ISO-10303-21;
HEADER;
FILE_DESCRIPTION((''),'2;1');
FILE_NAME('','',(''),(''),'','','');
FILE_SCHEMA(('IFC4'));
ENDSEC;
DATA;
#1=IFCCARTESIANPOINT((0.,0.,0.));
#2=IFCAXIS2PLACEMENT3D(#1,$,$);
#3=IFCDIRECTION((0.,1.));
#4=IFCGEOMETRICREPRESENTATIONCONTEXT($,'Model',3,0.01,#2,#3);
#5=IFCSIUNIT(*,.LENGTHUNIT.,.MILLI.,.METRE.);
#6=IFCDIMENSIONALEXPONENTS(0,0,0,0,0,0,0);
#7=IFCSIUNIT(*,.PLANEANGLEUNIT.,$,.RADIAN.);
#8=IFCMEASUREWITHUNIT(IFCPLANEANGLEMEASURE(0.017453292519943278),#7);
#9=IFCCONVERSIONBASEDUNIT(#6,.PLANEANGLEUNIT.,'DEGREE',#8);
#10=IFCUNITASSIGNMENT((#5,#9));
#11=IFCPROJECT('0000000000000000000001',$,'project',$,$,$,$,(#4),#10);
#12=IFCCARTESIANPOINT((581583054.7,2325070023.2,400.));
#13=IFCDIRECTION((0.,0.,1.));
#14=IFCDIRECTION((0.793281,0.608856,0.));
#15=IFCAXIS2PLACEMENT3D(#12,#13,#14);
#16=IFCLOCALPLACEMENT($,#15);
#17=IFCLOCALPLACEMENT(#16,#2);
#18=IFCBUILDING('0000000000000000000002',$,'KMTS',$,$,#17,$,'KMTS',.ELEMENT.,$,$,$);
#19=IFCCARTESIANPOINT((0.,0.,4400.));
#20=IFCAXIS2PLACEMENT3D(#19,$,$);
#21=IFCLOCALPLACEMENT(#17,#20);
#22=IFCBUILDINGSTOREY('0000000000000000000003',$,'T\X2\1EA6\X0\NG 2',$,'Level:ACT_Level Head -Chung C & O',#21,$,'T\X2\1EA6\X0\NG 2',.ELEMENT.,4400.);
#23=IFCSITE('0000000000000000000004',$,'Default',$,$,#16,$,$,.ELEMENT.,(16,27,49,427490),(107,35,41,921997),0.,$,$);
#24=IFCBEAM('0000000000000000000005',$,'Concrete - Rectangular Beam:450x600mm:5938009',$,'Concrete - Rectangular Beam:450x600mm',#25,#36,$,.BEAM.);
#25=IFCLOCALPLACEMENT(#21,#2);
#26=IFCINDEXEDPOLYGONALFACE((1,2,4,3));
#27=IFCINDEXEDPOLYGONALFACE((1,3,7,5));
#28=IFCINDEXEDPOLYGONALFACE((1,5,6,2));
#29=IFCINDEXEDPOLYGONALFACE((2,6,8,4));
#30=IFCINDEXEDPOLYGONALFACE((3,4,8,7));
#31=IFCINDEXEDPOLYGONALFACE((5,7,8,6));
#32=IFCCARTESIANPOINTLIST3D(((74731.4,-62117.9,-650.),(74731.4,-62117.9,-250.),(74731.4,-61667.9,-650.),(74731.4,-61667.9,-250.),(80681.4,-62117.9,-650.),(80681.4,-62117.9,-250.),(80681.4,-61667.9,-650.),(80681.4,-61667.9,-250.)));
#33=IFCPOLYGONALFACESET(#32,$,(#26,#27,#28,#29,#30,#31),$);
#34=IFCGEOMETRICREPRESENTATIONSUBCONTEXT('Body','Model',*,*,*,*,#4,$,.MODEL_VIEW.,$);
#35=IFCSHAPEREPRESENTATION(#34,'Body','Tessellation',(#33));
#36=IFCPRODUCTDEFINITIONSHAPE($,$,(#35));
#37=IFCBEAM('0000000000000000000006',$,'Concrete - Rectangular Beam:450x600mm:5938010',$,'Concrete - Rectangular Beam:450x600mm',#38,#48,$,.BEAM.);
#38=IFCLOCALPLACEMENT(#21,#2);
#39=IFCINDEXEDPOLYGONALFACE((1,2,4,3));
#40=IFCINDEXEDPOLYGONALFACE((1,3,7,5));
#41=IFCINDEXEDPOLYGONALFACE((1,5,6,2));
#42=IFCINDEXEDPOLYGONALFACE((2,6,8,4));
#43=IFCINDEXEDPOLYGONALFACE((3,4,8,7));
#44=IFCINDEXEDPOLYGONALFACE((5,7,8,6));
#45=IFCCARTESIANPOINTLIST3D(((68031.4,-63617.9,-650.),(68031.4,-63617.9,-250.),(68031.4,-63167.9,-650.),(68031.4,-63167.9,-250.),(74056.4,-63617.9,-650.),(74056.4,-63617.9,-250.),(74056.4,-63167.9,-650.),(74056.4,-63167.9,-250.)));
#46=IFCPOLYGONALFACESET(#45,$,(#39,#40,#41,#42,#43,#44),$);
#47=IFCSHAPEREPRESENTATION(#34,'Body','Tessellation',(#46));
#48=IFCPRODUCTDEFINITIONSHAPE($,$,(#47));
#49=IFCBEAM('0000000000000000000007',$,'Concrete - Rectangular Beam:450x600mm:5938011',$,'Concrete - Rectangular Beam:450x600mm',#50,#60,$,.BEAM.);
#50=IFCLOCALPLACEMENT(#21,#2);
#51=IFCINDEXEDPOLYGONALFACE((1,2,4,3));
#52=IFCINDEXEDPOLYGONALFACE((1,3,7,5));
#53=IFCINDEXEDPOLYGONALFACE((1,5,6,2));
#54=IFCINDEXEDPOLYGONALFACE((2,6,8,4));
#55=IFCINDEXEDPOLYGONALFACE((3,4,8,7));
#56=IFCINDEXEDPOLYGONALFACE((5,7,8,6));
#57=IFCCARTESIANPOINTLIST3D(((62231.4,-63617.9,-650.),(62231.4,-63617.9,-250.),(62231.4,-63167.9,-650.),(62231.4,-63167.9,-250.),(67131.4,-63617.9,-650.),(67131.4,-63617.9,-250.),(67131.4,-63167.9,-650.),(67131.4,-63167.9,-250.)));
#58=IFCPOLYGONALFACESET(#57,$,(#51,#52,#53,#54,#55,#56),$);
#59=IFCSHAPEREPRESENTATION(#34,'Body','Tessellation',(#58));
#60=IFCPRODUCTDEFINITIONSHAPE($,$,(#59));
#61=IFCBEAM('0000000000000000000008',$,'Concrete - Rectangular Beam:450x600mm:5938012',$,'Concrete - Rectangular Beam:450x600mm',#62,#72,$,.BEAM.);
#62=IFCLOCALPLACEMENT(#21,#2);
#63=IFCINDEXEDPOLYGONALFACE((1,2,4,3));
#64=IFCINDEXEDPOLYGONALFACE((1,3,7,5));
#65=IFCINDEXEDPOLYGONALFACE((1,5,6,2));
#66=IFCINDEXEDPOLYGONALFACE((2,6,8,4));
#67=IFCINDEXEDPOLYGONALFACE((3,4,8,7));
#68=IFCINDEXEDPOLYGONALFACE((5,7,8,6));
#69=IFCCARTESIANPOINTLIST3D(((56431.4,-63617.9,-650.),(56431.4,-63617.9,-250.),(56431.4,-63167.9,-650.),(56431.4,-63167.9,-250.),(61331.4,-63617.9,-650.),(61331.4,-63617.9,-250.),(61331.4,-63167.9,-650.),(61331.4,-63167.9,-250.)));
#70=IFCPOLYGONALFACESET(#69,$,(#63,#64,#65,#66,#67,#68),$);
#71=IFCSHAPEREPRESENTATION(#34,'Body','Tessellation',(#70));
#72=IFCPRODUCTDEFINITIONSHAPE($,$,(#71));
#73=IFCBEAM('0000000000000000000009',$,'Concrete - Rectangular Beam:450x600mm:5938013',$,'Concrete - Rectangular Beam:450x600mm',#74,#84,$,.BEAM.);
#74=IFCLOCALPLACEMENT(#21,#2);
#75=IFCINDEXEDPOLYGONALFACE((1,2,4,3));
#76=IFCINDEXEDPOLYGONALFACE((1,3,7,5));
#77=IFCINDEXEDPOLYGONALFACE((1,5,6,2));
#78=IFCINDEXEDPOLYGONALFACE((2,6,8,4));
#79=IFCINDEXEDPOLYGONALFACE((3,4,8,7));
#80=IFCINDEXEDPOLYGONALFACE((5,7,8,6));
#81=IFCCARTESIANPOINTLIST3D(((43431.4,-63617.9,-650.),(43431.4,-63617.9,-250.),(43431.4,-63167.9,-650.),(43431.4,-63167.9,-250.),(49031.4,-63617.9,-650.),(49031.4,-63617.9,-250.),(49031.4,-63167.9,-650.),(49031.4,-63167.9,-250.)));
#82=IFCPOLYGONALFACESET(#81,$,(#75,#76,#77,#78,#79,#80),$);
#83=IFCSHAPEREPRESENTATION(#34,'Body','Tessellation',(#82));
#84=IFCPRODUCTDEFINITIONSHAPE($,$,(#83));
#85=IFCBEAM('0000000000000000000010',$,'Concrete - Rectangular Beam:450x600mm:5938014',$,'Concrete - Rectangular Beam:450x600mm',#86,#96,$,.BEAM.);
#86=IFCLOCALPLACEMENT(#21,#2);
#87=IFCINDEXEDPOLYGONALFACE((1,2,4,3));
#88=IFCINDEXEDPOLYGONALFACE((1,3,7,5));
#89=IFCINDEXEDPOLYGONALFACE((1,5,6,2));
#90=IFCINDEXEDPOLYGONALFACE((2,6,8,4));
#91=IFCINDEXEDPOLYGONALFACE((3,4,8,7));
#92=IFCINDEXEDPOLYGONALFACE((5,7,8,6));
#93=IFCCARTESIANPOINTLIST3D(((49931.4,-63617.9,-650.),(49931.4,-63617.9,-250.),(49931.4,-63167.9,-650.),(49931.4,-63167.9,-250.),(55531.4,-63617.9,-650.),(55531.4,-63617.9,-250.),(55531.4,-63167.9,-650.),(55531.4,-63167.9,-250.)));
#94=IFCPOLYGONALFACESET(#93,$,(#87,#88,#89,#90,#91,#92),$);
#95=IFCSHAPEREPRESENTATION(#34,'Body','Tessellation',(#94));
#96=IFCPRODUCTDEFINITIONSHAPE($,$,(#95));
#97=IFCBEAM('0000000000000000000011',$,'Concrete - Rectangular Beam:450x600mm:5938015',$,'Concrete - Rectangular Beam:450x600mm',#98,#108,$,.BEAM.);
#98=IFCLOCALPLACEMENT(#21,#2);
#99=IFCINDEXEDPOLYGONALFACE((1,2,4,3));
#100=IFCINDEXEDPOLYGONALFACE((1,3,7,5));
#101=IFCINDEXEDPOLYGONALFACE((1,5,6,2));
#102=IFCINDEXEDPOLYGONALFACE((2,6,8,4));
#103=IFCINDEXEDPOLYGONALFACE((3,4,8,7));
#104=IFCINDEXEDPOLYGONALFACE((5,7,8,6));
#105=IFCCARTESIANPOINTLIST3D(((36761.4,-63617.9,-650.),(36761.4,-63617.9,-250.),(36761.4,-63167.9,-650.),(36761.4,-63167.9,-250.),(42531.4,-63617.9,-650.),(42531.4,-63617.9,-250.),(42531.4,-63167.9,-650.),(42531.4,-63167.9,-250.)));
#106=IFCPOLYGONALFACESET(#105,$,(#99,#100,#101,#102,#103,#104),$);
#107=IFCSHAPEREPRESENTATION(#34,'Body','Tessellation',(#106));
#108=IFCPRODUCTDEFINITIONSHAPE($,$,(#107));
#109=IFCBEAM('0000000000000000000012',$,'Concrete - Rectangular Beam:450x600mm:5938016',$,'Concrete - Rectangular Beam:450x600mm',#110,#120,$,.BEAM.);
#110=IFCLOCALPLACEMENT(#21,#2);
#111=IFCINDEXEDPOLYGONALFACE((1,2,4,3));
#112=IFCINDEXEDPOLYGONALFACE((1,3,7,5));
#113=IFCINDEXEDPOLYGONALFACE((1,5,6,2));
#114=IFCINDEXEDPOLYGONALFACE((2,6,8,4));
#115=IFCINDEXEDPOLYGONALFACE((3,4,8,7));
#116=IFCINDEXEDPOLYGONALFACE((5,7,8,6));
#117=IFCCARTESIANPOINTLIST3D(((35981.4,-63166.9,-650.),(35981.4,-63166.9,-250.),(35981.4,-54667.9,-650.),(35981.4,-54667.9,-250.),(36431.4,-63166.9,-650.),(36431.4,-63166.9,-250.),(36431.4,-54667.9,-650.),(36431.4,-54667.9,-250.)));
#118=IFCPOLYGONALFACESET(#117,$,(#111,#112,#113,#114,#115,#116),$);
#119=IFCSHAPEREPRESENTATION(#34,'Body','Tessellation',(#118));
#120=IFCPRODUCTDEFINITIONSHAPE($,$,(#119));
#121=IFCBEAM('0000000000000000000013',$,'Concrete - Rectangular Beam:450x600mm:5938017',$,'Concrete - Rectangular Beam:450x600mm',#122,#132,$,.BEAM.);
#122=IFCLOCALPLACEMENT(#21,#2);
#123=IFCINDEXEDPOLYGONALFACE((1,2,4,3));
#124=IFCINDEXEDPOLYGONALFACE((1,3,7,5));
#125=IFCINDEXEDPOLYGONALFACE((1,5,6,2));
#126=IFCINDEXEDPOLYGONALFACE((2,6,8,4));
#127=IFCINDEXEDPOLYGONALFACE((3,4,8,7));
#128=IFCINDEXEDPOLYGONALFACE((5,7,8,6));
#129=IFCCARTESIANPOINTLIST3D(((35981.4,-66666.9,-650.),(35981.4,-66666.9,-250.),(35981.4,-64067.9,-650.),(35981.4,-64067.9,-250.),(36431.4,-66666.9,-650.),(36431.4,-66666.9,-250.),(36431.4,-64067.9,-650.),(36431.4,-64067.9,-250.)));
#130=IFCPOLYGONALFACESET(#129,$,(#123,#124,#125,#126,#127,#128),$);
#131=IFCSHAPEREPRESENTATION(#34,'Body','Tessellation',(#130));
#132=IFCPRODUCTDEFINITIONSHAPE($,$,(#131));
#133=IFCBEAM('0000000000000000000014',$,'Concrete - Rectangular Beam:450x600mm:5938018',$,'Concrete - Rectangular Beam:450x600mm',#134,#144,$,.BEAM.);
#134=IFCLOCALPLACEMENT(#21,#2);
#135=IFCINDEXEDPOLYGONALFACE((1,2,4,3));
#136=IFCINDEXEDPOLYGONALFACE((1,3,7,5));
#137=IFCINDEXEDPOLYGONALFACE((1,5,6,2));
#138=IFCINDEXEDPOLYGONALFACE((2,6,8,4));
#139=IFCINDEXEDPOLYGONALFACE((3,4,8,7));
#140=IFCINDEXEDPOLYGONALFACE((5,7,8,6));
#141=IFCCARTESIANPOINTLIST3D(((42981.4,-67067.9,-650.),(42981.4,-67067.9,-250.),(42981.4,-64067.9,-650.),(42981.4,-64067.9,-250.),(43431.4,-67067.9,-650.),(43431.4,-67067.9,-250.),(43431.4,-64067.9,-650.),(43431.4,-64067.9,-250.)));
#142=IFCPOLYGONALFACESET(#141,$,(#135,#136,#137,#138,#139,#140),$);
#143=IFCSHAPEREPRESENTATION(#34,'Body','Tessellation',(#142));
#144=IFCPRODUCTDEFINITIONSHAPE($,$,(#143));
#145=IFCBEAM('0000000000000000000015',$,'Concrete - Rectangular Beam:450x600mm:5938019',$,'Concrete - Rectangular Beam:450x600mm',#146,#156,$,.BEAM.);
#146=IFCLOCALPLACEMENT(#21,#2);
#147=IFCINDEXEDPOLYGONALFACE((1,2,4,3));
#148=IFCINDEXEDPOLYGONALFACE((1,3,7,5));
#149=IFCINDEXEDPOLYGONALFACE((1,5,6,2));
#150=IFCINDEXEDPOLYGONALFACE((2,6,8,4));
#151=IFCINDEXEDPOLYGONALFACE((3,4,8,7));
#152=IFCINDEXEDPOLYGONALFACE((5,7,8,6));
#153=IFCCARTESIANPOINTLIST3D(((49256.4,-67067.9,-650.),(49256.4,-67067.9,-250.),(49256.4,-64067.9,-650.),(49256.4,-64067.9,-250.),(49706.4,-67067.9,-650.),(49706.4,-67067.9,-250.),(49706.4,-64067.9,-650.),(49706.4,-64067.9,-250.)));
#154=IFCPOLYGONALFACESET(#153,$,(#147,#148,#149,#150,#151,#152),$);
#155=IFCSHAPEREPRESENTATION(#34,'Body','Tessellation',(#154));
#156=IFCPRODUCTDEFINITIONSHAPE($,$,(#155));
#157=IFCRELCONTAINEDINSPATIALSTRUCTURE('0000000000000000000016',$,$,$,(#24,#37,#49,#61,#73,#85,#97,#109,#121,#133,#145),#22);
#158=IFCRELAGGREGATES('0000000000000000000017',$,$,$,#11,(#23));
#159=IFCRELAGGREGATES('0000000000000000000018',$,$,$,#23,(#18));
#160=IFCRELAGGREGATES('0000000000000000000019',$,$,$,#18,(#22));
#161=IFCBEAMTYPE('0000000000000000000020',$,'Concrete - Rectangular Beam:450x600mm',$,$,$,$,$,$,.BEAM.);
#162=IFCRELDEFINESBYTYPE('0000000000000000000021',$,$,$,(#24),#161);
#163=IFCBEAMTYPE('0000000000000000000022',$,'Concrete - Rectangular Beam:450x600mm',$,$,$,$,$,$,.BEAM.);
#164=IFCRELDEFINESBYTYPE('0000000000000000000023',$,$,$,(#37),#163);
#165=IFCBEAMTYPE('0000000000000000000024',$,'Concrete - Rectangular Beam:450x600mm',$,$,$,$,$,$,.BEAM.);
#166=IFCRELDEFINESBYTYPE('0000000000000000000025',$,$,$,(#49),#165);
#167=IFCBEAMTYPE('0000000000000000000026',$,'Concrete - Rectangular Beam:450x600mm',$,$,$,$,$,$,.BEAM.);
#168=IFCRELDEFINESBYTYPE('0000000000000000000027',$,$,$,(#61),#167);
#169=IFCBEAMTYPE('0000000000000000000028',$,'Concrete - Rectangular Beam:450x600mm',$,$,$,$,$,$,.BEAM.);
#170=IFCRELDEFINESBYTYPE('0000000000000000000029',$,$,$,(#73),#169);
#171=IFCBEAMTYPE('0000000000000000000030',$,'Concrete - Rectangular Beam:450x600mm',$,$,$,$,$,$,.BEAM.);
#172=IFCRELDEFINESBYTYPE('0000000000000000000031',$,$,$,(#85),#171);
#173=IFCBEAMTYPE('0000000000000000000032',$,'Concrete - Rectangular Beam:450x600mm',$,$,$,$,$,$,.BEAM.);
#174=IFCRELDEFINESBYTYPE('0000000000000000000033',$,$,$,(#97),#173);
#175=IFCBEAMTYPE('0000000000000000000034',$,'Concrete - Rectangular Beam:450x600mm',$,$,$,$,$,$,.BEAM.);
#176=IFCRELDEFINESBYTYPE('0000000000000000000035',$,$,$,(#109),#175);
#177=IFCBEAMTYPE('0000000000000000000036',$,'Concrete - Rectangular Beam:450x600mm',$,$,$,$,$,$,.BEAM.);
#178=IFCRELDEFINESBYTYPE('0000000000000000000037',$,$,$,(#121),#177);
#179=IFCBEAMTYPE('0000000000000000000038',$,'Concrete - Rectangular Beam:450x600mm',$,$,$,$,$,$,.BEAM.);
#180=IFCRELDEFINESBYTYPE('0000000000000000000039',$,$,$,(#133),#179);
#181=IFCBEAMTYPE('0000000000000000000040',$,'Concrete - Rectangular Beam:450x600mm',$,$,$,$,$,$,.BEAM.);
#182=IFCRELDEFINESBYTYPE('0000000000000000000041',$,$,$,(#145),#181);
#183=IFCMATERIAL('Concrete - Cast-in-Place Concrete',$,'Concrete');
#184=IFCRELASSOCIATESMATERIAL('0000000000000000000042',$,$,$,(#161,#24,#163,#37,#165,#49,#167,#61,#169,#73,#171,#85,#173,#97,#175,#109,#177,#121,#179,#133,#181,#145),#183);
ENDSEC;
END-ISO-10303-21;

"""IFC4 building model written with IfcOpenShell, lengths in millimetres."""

from ifc_helpers import new_model, entity, si_unit, converted_unit, direction, frame, origin, place, context, subcontext, project, spatial, indexed_curve, outline, extrude, source, transform, mapped, material, type_object, type_shapes, element, save


model = new_model("IFC4")

# Units and contexts
model_context = context("Model", 3, precision=0.01, world=origin(), true_north=direction((0.0, 1.0)))
body_context = subcontext(model_context, "Body", "Model", "MODEL_VIEW")
ifc_project = project(units=[si_unit("LENGTHUNIT", "METRE", prefix="MILLI"), converted_unit("PLANEANGLEUNIT", "DEGREE", entity("IfcPlaneAngleMeasure", 0.017453292519943278), si_unit("PLANEANGLEUNIT", "RADIAN"), dimensions=[0, 0, 0, 0, 0, 0, 0])], contexts=[model_context])

# Site, building, storey
site_placement = place(None, frame((581583054.7, 2325070023.2, 400.0), z_axis=(0.0, 0.0, 1.0), x_axis=(0.793281, 0.608856, 0.0)))
site = spatial("IfcSite", under=ifc_project, at=site_placement, Name="Default", CompositionType="ELEMENT", RefLatitude=(16, 27, 49, 427490), RefLongitude=(107, 35, 41, 921997), RefElevation=0.0)
building_placement = place(site_placement, origin())
building = spatial("IfcBuilding", under=site, at=building_placement, Name="KMTS", LongName="KMTS", CompositionType="ELEMENT")
storey_placement = place(building_placement, frame((0.0, 0.0, 4400.0)))
storey = spatial("IfcBuildingStorey", under=building, at=storey_placement, Name="TẦNG 2", ObjectType="Level:ACT_Level Head -Chung C & O", LongName="TẦNG 2", CompositionType="ELEMENT", Elevation=4400.0)

# Beams
ifc_material_1 = material(Name="Concrete - Cast-in-Place Concrete", Category="Concrete")
beam_type_1 = type_object("IfcBeamType", Name="Concrete - Rectangular Beam:450x600mm", PredefinedType="BEAM", material=ifc_material_1)
shared_shape_1 = source(origin(), body_context, "Body", "SweptSolid", [
    extrude(outline(indexed_curve([(-200.0, -225.0), (200.0, -225.0), (200.0, 225.0), (-200.0, 225.0), (-200.0, -225.0)], self_intersect=False)), frame((74731.4, -61892.9, 3950.0), z_axis=(1.0, 0.0, 0.0), x_axis=(0.0, 0.0, -1.0)), (0.0, 0.0, 1.0), 5950.0),
])
type_shapes(beam_type_1, [shared_shape_1])
beam_1_placement = place(storey_placement, frame((0.0, 0.0, -4400.0)))
element("IfcBeam", 1, at=beam_1_placement, inside=storey, type_object=beam_type_1, material=ifc_material_1, Name="Concrete - Rectangular Beam:450x600mm:5938009", ObjectType="Concrete - Rectangular Beam:450x600mm", PredefinedType="BEAM", context=body_context, shape_type="MappedRepresentation", body=[
    mapped(shared_shape_1, transform((0.0, 0.0, 0.0), scale=1.0)),
])
beam_type_2 = type_object("IfcBeamType", Name="Concrete - Rectangular Beam:450x600mm", PredefinedType="BEAM", material=ifc_material_1)
shared_shape_2 = source(origin(), body_context, "Body", "SweptSolid", [
    extrude(outline(indexed_curve([(-200.0, -225.0), (200.0, -225.0), (200.0, 225.0), (-200.0, 225.0), (-200.0, -225.0)], self_intersect=False)), frame((68031.4, -63392.9, 3950.0), z_axis=(1.0, 0.0, 0.0), x_axis=(0.0, 0.0, -1.0)), (0.0, 0.0, 1.0), 6025.0),
])
type_shapes(beam_type_2, [shared_shape_2])
beam_2_placement = place(storey_placement, frame((0.0, 0.0, -4400.0)))
element("IfcBeam", 2, at=beam_2_placement, inside=storey, type_object=beam_type_2, material=ifc_material_1, Name="Concrete - Rectangular Beam:450x600mm:5938010", ObjectType="Concrete - Rectangular Beam:450x600mm", PredefinedType="BEAM", context=body_context, shape_type="MappedRepresentation", body=[
    mapped(shared_shape_2, transform((0.0, 0.0, 0.0), scale=1.0)),
])
beam_type_3 = type_object("IfcBeamType", Name="Concrete - Rectangular Beam:450x600mm", PredefinedType="BEAM", material=ifc_material_1)
shared_shape_3 = source(origin(), body_context, "Body", "SweptSolid", [
    extrude(outline(indexed_curve([(-200.0, -225.0), (200.0, -225.0), (200.0, 225.0), (-200.0, 225.0), (-200.0, -225.0)], self_intersect=False)), frame((62231.4, -63392.9, 3950.0), z_axis=(1.0, 0.0, 0.0), x_axis=(0.0, 0.0, -1.0)), (0.0, 0.0, 1.0), 4900.0),
])
type_shapes(beam_type_3, [shared_shape_3])
beam_3_placement = place(storey_placement, frame((0.0, 0.0, -4400.0)))
element("IfcBeam", 3, at=beam_3_placement, inside=storey, type_object=beam_type_3, material=ifc_material_1, Name="Concrete - Rectangular Beam:450x600mm:5938011", ObjectType="Concrete - Rectangular Beam:450x600mm", PredefinedType="BEAM", context=body_context, shape_type="MappedRepresentation", body=[
    mapped(shared_shape_3, transform((0.0, 0.0, 0.0), scale=1.0)),
])
beam_type_4 = type_object("IfcBeamType", Name="Concrete - Rectangular Beam:450x600mm", PredefinedType="BEAM", material=ifc_material_1)
shared_shape_4 = source(origin(), body_context, "Body", "SweptSolid", [
    extrude(outline(indexed_curve([(-200.0, -225.0), (200.0, -225.0), (200.0, 225.0), (-200.0, 225.0), (-200.0, -225.0)], self_intersect=False)), frame((56431.4, -63392.9, 3950.0), z_axis=(1.0, 0.0, 0.0), x_axis=(0.0, 0.0, -1.0)), (0.0, 0.0, 1.0), 4900.0),
])
type_shapes(beam_type_4, [shared_shape_4])
beam_4_placement = place(storey_placement, frame((0.0, 0.0, -4400.0)))
element("IfcBeam", 4, at=beam_4_placement, inside=storey, type_object=beam_type_4, material=ifc_material_1, Name="Concrete - Rectangular Beam:450x600mm:5938012", ObjectType="Concrete - Rectangular Beam:450x600mm", PredefinedType="BEAM", context=body_context, shape_type="MappedRepresentation", body=[
    mapped(shared_shape_4, transform((0.0, 0.0, 0.0), scale=1.0)),
])
beam_type_5 = type_object("IfcBeamType", Name="Concrete - Rectangular Beam:450x600mm", PredefinedType="BEAM", material=ifc_material_1)
shared_shape_5 = source(origin(), body_context, "Body", "SweptSolid", [
    extrude(outline(indexed_curve([(-200.0, -225.0), (200.0, -225.0), (200.0, 225.0), (-200.0, 225.0), (-200.0, -225.0)], self_intersect=False)), frame((43431.4, -63392.9, 3950.0), z_axis=(1.0, 0.0, 0.0), x_axis=(0.0, 0.0, -1.0)), (0.0, 0.0, 1.0), 5600.0),
])
type_shapes(beam_type_5, [shared_shape_5])
beam_5_placement = place(storey_placement, frame((0.0, 0.0, -4400.0)))
element("IfcBeam", 5, at=beam_5_placement, inside=storey, type_object=beam_type_5, material=ifc_material_1, Name="Concrete - Rectangular Beam:450x600mm:5938013", ObjectType="Concrete - Rectangular Beam:450x600mm", PredefinedType="BEAM", context=body_context, shape_type="MappedRepresentation", body=[
    mapped(shared_shape_5, transform((0.0, 0.0, 0.0), scale=1.0)),
])
beam_type_6 = type_object("IfcBeamType", Name="Concrete - Rectangular Beam:450x600mm", PredefinedType="BEAM", material=ifc_material_1)
shared_shape_6 = source(origin(), body_context, "Body", "SweptSolid", [
    extrude(outline(indexed_curve([(-200.0, -225.0), (200.0, -225.0), (200.0, 225.0), (-200.0, 225.0), (-200.0, -225.0)], self_intersect=False)), frame((49931.4, -63392.9, 3950.0), z_axis=(1.0, 0.0, 0.0), x_axis=(0.0, 0.0, -1.0)), (0.0, 0.0, 1.0), 5600.0),
])
type_shapes(beam_type_6, [shared_shape_6])
beam_6_placement = place(storey_placement, frame((0.0, 0.0, -4400.0)))
element("IfcBeam", 6, at=beam_6_placement, inside=storey, type_object=beam_type_6, material=ifc_material_1, Name="Concrete - Rectangular Beam:450x600mm:5938014", ObjectType="Concrete - Rectangular Beam:450x600mm", PredefinedType="BEAM", context=body_context, shape_type="MappedRepresentation", body=[
    mapped(shared_shape_6, transform((0.0, 0.0, 0.0), scale=1.0)),
])
beam_type_7 = type_object("IfcBeamType", Name="Concrete - Rectangular Beam:450x600mm", PredefinedType="BEAM", material=ifc_material_1)
shared_shape_7 = source(origin(), body_context, "Body", "SweptSolid", [
    extrude(outline(indexed_curve([(-200.0, -225.0), (200.0, -225.0), (200.0, 225.0), (-200.0, 225.0), (-200.0, -225.0)], self_intersect=False)), frame((36761.4, -63392.9, 3950.0), z_axis=(1.0, 0.0, 0.0), x_axis=(0.0, 0.0, -1.0)), (0.0, 0.0, 1.0), 5770.0),
])
type_shapes(beam_type_7, [shared_shape_7])
beam_7_placement = place(storey_placement, frame((0.0, 0.0, -4400.0)))
element("IfcBeam", 7, at=beam_7_placement, inside=storey, type_object=beam_type_7, material=ifc_material_1, Name="Concrete - Rectangular Beam:450x600mm:5938015", ObjectType="Concrete - Rectangular Beam:450x600mm", PredefinedType="BEAM", context=body_context, shape_type="MappedRepresentation", body=[
    mapped(shared_shape_7, transform((0.0, 0.0, 0.0), scale=1.0)),
])
beam_type_8 = type_object("IfcBeamType", Name="Concrete - Rectangular Beam:450x600mm", PredefinedType="BEAM", material=ifc_material_1)
shared_shape_8 = source(origin(), body_context, "Body", "SweptSolid", [
    extrude(outline(indexed_curve([(-225.0, -200.0), (225.0, -200.0), (225.0, 200.0), (-225.0, 200.0), (-225.0, -200.0)], self_intersect=False)), frame((36206.4, -54667.9, 3950.0), z_axis=(0.0, -1.0, 0.0), x_axis=(-1.0, 0.0, 0.0)), (0.0, 0.0, 1.0), 8499.0),
])
type_shapes(beam_type_8, [shared_shape_8])
beam_8_placement = place(storey_placement, frame((0.0, 0.0, -4400.0)))
element("IfcBeam", 8, at=beam_8_placement, inside=storey, type_object=beam_type_8, material=ifc_material_1, Name="Concrete - Rectangular Beam:450x600mm:5938016", ObjectType="Concrete - Rectangular Beam:450x600mm", PredefinedType="BEAM", context=body_context, shape_type="MappedRepresentation", body=[
    mapped(shared_shape_8, transform((0.0, 0.0, 0.0), scale=1.0)),
])
beam_type_9 = type_object("IfcBeamType", Name="Concrete - Rectangular Beam:450x600mm", PredefinedType="BEAM", material=ifc_material_1)
shared_shape_9 = source(origin(), body_context, "Body", "SweptSolid", [
    extrude(outline(indexed_curve([(-225.0, -200.0), (225.0, -200.0), (225.0, 200.0), (-225.0, 200.0), (-225.0, -200.0)], self_intersect=False)), frame((36206.4, -66666.9, 3950.0), z_axis=(0.0, 1.0, 0.0), x_axis=(-1.0, 0.0, 0.0)), (0.0, 0.0, 1.0), 2599.0),
])
type_shapes(beam_type_9, [shared_shape_9])
beam_9_placement = place(storey_placement, frame((0.0, 0.0, -4400.0)))
element("IfcBeam", 9, at=beam_9_placement, inside=storey, type_object=beam_type_9, material=ifc_material_1, Name="Concrete - Rectangular Beam:450x600mm:5938017", ObjectType="Concrete - Rectangular Beam:450x600mm", PredefinedType="BEAM", context=body_context, shape_type="MappedRepresentation", body=[
    mapped(shared_shape_9, transform((0.0, 0.0, 0.0), scale=1.0)),
])
beam_type_10 = type_object("IfcBeamType", Name="Concrete - Rectangular Beam:450x600mm", PredefinedType="BEAM", material=ifc_material_1)
shared_shape_10 = source(origin(), body_context, "Body", "SweptSolid", [
    extrude(outline(indexed_curve([(-225.0, -200.0), (225.0, -200.0), (225.0, 200.0), (-225.0, 200.0), (-225.0, -200.0)], self_intersect=False)), frame((43206.4, -67067.9, 3950.0), z_axis=(0.0, 1.0, 0.0), x_axis=(-1.0, 0.0, 0.0)), (0.0, 0.0, 1.0), 3000.0),
])
type_shapes(beam_type_10, [shared_shape_10])
beam_10_placement = place(storey_placement, frame((0.0, 0.0, -4400.0)))
element("IfcBeam", 10, at=beam_10_placement, inside=storey, type_object=beam_type_10, material=ifc_material_1, Name="Concrete - Rectangular Beam:450x600mm:5938018", ObjectType="Concrete - Rectangular Beam:450x600mm", PredefinedType="BEAM", context=body_context, shape_type="MappedRepresentation", body=[
    mapped(shared_shape_10, transform((0.0, 0.0, 0.0), scale=1.0)),
])
beam_type_11 = type_object("IfcBeamType", Name="Concrete - Rectangular Beam:450x600mm", PredefinedType="BEAM", material=ifc_material_1)
shared_shape_11 = source(origin(), body_context, "Body", "SweptSolid", [
    extrude(outline(indexed_curve([(-225.0, -200.0), (225.0, -200.0), (225.0, 200.0), (-225.0, 200.0), (-225.0, -200.0)], self_intersect=False)), frame((49481.4, -67067.9, 3950.0), z_axis=(0.0, 1.0, 0.0), x_axis=(-1.0, 0.0, 0.0)), (0.0, 0.0, 1.0), 3000.0),
])
type_shapes(beam_type_11, [shared_shape_11])
beam_11_placement = place(storey_placement, frame((0.0, 0.0, -4400.0)))
element("IfcBeam", 11, at=beam_11_placement, inside=storey, type_object=beam_type_11, material=ifc_material_1, Name="Concrete - Rectangular Beam:450x600mm:5938019", ObjectType="Concrete - Rectangular Beam:450x600mm", PredefinedType="BEAM", context=body_context, shape_type="MappedRepresentation", body=[
    mapped(shared_shape_11, transform((0.0, 0.0, 0.0), scale=1.0)),
])

save(model, "model.ifc")
